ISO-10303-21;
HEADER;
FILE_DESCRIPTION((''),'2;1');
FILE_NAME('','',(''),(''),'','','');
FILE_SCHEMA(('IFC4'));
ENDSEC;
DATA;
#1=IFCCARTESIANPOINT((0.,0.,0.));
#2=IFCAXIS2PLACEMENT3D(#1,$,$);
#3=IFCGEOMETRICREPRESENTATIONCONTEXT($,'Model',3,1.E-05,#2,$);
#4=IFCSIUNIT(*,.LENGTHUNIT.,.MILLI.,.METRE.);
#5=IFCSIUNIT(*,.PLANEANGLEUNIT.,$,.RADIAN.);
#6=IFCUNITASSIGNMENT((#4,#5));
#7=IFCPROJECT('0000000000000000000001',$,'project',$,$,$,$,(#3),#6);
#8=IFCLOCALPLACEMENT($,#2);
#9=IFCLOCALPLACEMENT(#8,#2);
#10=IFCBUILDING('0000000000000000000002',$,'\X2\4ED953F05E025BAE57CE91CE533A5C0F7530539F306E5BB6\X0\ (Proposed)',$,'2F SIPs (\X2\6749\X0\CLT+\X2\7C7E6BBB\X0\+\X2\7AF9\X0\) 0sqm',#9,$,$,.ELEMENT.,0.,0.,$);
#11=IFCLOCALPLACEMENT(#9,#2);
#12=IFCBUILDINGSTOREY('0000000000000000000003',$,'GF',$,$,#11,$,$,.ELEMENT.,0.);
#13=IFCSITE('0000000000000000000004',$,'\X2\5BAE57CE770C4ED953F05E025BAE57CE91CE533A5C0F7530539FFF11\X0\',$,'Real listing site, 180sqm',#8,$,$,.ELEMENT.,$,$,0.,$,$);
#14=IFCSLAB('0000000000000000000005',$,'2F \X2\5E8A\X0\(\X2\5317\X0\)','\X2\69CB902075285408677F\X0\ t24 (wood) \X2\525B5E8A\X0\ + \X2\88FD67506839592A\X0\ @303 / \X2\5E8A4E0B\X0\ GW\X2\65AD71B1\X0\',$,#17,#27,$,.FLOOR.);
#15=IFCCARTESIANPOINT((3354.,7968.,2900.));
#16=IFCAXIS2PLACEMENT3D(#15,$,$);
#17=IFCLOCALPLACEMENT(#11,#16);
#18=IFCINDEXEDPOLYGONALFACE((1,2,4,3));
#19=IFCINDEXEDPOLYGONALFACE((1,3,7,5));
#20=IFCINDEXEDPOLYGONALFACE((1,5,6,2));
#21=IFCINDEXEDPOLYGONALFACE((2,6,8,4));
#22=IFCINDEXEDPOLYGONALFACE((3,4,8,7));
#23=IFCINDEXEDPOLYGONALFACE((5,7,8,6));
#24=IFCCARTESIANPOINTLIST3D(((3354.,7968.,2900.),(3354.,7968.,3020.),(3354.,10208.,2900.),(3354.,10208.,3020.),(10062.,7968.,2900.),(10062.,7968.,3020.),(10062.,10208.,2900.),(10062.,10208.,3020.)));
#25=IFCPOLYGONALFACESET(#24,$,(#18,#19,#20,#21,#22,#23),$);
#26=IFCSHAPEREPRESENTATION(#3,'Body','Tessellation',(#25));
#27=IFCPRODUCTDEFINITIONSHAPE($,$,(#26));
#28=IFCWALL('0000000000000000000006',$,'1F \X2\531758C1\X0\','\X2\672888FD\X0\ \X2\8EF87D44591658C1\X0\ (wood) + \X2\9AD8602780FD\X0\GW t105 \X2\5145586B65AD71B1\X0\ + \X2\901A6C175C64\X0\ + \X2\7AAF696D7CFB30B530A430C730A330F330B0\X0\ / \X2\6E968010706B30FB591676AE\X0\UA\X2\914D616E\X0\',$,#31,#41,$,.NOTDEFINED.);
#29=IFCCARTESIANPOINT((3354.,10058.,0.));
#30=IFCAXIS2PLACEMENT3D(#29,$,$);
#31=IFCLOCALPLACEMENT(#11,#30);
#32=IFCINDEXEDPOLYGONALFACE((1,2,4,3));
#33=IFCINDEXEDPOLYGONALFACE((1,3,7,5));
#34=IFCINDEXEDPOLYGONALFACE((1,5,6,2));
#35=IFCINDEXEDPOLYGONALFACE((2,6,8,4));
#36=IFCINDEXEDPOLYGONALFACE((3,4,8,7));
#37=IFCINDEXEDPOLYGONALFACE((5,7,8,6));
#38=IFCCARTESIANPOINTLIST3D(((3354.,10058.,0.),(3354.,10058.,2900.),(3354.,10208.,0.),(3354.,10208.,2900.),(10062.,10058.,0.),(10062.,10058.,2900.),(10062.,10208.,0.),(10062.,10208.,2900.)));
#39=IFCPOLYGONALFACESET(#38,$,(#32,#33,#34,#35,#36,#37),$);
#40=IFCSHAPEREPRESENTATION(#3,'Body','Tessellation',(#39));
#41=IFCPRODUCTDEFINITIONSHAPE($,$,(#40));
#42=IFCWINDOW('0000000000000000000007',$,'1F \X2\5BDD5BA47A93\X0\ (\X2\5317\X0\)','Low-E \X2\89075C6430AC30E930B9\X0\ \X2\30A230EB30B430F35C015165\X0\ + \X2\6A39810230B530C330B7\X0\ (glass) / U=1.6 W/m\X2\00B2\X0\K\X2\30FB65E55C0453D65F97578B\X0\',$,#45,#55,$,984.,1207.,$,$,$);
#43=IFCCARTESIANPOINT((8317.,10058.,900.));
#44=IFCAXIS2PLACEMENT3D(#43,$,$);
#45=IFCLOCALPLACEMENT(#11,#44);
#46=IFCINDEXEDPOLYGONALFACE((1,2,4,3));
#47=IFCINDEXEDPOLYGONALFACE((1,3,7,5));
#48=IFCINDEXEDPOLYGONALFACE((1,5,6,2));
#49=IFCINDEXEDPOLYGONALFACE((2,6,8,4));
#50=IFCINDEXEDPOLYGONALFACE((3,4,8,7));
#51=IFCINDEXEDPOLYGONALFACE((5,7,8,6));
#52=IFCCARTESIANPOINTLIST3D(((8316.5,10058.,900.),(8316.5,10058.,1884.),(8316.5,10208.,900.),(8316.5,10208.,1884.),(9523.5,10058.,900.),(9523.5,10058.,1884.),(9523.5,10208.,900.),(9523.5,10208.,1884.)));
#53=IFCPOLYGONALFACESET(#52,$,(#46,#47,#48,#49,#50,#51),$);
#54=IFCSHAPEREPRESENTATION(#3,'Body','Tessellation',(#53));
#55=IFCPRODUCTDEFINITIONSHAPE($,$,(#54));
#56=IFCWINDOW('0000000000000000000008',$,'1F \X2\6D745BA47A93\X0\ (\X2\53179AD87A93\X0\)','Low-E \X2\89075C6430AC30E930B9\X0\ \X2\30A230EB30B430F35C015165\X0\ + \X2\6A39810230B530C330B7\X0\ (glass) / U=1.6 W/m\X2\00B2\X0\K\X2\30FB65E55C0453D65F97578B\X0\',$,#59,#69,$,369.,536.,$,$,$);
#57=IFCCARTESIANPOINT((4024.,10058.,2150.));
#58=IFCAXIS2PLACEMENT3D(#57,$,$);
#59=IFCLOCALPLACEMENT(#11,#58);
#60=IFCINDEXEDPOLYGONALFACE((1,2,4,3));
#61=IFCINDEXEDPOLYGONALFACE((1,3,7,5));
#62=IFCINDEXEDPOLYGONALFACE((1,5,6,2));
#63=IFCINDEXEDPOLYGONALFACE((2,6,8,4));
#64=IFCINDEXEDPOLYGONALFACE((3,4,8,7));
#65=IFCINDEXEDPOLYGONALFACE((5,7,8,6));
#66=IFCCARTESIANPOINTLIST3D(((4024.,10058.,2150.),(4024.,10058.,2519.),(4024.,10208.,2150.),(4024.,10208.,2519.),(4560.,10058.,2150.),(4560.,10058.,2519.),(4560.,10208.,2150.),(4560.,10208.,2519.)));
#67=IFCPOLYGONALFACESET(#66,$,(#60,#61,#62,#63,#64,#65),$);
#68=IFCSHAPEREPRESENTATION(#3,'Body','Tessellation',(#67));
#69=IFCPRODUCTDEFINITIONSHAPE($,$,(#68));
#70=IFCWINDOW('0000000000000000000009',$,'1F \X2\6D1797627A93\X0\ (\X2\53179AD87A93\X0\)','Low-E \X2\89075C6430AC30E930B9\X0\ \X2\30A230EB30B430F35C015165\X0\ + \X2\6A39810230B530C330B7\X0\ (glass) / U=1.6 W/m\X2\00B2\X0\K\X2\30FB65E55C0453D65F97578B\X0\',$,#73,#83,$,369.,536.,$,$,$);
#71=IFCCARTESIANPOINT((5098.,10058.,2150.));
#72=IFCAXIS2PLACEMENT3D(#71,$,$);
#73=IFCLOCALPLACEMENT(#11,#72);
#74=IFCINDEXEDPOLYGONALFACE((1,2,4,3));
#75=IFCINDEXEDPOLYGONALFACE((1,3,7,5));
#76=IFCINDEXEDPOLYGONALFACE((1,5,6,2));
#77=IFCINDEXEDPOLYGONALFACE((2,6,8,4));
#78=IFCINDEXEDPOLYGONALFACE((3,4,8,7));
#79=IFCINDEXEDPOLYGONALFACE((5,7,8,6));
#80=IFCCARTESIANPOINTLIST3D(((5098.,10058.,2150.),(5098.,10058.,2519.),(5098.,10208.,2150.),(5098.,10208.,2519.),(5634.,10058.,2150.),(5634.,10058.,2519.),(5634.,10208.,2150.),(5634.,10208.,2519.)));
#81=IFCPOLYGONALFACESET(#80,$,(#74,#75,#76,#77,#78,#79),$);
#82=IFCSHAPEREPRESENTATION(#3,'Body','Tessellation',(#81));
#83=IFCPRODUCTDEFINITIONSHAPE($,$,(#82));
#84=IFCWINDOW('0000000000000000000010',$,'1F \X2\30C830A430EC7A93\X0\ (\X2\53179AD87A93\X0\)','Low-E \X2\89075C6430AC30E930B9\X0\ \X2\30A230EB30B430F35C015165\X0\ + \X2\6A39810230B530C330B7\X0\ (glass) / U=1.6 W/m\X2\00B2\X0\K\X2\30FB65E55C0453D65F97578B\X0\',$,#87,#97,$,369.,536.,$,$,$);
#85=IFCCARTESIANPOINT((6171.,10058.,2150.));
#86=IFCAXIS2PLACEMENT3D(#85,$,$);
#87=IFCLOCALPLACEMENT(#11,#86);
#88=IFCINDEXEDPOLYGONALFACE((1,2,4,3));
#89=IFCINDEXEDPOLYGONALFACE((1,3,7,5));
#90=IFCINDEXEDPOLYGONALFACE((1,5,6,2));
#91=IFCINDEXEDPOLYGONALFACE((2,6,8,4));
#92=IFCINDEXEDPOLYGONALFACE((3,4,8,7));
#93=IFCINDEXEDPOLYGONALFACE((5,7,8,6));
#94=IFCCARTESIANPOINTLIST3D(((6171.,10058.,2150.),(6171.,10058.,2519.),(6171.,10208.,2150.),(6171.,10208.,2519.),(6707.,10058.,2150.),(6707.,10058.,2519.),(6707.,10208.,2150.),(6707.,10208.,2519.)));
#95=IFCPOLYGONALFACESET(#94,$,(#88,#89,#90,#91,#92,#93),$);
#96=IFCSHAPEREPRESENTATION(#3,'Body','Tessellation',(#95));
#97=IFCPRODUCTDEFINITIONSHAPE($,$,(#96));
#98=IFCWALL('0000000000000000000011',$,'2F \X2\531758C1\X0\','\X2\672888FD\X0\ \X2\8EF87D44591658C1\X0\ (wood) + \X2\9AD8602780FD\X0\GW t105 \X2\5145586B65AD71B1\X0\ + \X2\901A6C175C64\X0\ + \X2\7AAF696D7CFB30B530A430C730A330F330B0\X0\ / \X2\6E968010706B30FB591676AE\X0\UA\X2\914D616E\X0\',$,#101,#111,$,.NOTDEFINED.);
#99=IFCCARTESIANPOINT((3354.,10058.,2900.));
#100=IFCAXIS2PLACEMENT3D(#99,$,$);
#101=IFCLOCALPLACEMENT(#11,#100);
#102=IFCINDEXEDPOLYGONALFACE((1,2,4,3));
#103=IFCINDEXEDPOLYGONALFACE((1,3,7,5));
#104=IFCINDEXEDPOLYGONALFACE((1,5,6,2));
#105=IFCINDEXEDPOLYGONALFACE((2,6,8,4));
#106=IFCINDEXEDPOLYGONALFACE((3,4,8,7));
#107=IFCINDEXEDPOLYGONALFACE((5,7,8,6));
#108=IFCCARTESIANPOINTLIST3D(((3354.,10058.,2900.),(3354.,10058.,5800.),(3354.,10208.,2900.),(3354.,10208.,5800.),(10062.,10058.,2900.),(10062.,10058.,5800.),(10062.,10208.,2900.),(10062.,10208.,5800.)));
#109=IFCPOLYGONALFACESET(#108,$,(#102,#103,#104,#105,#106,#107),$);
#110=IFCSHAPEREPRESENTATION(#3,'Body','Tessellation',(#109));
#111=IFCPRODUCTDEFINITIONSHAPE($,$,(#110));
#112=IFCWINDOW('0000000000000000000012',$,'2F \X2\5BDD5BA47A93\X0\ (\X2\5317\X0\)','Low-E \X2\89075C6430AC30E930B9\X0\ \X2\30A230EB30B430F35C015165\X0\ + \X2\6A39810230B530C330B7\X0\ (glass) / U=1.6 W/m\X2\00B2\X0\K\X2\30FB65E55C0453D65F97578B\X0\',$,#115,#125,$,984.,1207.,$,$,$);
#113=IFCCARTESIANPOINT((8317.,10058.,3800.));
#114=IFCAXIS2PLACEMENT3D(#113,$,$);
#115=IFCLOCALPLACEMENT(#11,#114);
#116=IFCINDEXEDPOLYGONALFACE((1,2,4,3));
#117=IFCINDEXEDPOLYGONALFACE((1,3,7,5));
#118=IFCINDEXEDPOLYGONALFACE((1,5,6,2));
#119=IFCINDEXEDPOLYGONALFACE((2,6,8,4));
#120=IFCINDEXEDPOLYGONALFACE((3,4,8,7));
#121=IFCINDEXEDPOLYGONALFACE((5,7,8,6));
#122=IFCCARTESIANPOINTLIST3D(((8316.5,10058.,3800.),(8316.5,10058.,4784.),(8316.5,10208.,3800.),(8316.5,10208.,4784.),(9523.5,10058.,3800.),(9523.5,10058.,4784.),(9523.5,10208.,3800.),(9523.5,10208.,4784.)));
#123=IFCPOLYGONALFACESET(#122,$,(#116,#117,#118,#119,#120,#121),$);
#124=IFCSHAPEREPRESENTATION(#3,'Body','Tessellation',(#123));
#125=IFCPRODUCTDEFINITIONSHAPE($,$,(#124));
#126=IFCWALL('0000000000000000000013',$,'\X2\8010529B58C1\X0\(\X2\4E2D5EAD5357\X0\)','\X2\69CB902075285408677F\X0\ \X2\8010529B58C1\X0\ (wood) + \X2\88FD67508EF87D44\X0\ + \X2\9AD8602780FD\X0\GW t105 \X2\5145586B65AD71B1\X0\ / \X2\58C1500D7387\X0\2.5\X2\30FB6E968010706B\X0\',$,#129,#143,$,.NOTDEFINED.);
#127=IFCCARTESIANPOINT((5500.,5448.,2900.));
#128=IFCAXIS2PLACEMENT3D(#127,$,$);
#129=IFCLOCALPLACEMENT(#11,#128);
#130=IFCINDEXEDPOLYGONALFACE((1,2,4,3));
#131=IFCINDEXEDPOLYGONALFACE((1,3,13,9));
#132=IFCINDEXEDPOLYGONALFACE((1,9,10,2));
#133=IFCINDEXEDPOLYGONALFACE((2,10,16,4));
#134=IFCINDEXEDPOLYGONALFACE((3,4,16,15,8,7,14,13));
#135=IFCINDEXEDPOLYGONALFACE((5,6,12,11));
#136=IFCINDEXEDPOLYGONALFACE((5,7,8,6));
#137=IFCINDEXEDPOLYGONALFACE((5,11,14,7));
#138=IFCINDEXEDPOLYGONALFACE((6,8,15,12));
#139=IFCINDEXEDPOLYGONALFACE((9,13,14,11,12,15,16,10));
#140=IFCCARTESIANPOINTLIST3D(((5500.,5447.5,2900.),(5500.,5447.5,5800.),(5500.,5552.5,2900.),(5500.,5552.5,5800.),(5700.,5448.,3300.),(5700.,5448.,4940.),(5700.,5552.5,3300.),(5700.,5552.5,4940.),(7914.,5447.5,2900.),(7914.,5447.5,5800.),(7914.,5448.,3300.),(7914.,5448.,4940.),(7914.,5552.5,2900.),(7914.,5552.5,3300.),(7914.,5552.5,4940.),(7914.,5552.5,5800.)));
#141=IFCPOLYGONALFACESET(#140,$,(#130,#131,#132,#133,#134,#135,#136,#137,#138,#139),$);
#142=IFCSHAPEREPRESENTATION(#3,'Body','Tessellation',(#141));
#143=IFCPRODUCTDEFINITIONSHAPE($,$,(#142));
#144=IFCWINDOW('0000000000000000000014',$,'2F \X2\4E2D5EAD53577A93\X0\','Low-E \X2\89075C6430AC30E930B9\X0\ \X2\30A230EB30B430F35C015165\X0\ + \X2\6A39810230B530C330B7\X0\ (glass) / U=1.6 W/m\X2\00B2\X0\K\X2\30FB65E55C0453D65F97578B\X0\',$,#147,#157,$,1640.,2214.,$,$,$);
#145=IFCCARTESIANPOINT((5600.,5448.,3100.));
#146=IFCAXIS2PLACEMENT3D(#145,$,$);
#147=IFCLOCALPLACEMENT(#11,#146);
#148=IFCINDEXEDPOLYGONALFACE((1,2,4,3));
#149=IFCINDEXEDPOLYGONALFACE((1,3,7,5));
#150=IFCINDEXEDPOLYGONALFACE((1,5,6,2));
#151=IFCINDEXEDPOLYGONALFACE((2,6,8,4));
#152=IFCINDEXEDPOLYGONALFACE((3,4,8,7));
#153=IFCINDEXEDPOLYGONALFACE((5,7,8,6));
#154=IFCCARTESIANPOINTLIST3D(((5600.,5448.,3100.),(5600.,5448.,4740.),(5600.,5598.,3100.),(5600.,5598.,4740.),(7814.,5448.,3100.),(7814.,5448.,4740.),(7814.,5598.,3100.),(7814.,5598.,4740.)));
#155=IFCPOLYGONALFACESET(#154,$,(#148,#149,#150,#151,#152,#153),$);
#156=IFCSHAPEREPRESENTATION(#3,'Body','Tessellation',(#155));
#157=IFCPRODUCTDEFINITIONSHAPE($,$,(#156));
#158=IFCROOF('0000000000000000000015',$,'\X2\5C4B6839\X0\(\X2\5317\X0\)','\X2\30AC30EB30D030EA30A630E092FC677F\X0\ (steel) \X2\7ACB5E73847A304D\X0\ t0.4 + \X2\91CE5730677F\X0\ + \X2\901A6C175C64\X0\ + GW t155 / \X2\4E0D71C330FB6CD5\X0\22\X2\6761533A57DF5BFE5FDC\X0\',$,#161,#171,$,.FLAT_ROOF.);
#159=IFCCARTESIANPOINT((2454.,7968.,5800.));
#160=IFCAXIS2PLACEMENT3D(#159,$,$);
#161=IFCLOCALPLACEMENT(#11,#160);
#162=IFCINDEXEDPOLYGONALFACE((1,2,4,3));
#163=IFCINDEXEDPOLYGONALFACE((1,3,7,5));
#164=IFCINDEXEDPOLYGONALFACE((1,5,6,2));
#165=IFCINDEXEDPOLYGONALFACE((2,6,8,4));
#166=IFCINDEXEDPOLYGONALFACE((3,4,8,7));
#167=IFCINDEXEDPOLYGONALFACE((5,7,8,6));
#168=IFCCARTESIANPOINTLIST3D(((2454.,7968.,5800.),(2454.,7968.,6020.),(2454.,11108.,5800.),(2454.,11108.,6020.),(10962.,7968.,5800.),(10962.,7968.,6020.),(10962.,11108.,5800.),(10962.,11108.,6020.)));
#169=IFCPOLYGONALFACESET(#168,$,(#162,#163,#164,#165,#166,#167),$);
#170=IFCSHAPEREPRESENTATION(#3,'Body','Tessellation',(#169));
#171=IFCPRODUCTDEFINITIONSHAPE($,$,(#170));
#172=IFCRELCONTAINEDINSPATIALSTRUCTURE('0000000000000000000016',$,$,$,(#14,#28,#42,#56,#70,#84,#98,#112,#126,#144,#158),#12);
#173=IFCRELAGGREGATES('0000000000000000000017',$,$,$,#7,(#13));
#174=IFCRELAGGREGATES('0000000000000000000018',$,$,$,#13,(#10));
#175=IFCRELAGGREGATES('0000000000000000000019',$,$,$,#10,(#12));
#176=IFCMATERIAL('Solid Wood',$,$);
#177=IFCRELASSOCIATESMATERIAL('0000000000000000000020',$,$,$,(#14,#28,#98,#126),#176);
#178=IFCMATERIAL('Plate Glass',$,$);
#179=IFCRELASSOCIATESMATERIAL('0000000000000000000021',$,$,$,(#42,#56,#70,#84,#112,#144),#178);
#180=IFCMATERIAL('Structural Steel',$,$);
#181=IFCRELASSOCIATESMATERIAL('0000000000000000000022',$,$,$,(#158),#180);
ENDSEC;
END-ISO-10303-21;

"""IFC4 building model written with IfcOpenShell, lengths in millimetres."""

from ifc_helpers import new_model, si_unit, frame, frame_2d, origin, place, context, project, spatial, rectangle, extrude, material, element, fill, save


model = new_model("IFC4")

# Units and contexts
model_context = context("Model", 3, precision=1e-05, world=origin())
ifc_project = project(units=[si_unit("LENGTHUNIT", "METRE", prefix="MILLI"), si_unit("PLANEANGLEUNIT", "RADIAN")], contexts=[model_context])

# Site, building, storey
site_placement = place(None, origin())
site = spatial("IfcSite", under=ifc_project, at=site_placement, Name="宮城県仙台市宮城野区小田原１", ObjectType="Real listing site, 180sqm", CompositionType="ELEMENT", RefElevation=0.0)
building_placement = place(site_placement, origin())
building = spatial("IfcBuilding", under=site, at=building_placement, Name="仙台市宮城野区小田原の家 (Proposed)", ObjectType="2F SIPs (杉CLT+籾殻+竹) 0sqm", CompositionType="ELEMENT", ElevationOfRefHeight=0.0, ElevationOfTerrain=0.0)
storey_placement = place(building_placement, origin())
storey = spatial("IfcBuildingStorey", under=building, at=storey_placement, Name="GF", CompositionType="ELEMENT", Elevation=0.0)

# Slab
ifc_material_1 = material(Name="Solid Wood")
slab_1_placement = place(storey_placement, frame((3354.0, 7968.0, 2900.0)))
element("IfcSlab", 1, at=slab_1_placement, inside=storey, material=ifc_material_1, Name="2F 床(北)", Description="構造用合板 t24 (wood) 剛床 + 製材根太 @303 / 床下 GW断熱", PredefinedType="FLOOR", context=model_context, shape_type="SweptSolid", body=[
    extrude(rectangle(XDim=6708.0, YDim=2240.0, at=frame_2d((3354.0, 1120.0))), frame((3354.0, 7968.0, 2900.0)), (0.0, 0.0, 1.0), 120.0),
])

# Wall, openings, windows
wall_1_placement = place(storey_placement, frame((3354.0, 10058.0, 0.0)))
wall_1 = element("IfcWall", 2, at=wall_1_placement, inside=storey, material=ifc_material_1, Name="1F 北壁", Description="木製 軸組外壁 (wood) + 高性能GW t105 充填断熱 + 通気層 + 窯業系サイディング / 準耐火・外皮UA配慮", PredefinedType="NOTDEFINED", context=model_context, shape_type="SweptSolid", body=[
    extrude(rectangle(XDim=6708.0, YDim=150.0, at=frame_2d((3354.0, 75.0))), frame((3354.0, 10058.0, 0.0)), (0.0, 0.0, 1.0), 2900.0),
])
opening_1_placement = place(storey_placement, frame((8317.0, 10058.0, 900.0)))
opening_1 = element("IfcOpeningElement", 3, at=opening_1_placement, cuts=wall_1, PredefinedType="NOTDEFINED", context=model_context, shape_type="SweptSolid", body=[
    extrude(rectangle(XDim=1207.0, YDim=150.0, at=frame_2d((603.0, 75.0))), frame((8317.0, 10058.0, 900.0)), (0.0, 0.0, 1.0), 984.0),
])
opening_2_placement = place(storey_placement, frame((4024.0, 10058.0, 2150.0)))
opening_2 = element("IfcOpeningElement", 4, at=opening_2_placement, cuts=wall_1, PredefinedType="NOTDEFINED", context=model_context, shape_type="SweptSolid", body=[
    extrude(rectangle(XDim=536.0, YDim=150.0, at=frame_2d((268.0, 75.0))), frame((4024.0, 10058.0, 2150.0)), (0.0, 0.0, 1.0), 369.0),
])
opening_3_placement = place(storey_placement, frame((5098.0, 10058.0, 2150.0)))
opening_3 = element("IfcOpeningElement", 5, at=opening_3_placement, cuts=wall_1, PredefinedType="NOTDEFINED", context=model_context, shape_type="SweptSolid", body=[
    extrude(rectangle(XDim=536.0, YDim=150.0, at=frame_2d((268.0, 75.0))), frame((5098.0, 10058.0, 2150.0)), (0.0, 0.0, 1.0), 369.0),
])
opening_4_placement = place(storey_placement, frame((6171.0, 10058.0, 2150.0)))
opening_4 = element("IfcOpeningElement", 6, at=opening_4_placement, cuts=wall_1, PredefinedType="NOTDEFINED", context=model_context, shape_type="SweptSolid", body=[
    extrude(rectangle(XDim=536.0, YDim=150.0, at=frame_2d((268.0, 75.0))), frame((6171.0, 10058.0, 2150.0)), (0.0, 0.0, 1.0), 369.0),
])
ifc_material_2 = material(Name="Plate Glass")
window_1_placement = place(storey_placement, frame((8317.0, 10058.0, 900.0)))
window_1 = element("IfcWindow", 7, at=window_1_placement, inside=storey, material=ifc_material_2, Name="1F 寝室窓 (北)", Description="Low-E 複層ガラス アルゴン封入 + 樹脂サッシ (glass) / U=1.6 W/m²K・日射取得型", OverallHeight=984.0, OverallWidth=1207.0, context=model_context, shape_type="SweptSolid", body=[
    extrude(rectangle(XDim=1207.0, YDim=150.0, at=frame_2d((603.0, 75.0))), frame((8317.0, 10058.0, 900.0)), (0.0, 0.0, 1.0), 984.0),
])
fill(opening_1, window_1)
window_2_placement = place(storey_placement, frame((4024.0, 10058.0, 2150.0)))
window_2 = element("IfcWindow", 8, at=window_2_placement, inside=storey, material=ifc_material_2, Name="1F 浴室窓 (北高窓)", Description="Low-E 複層ガラス アルゴン封入 + 樹脂サッシ (glass) / U=1.6 W/m²K・日射取得型", OverallHeight=369.0, OverallWidth=536.0, context=model_context, shape_type="SweptSolid", body=[
    extrude(rectangle(XDim=536.0, YDim=150.0, at=frame_2d((268.0, 75.0))), frame((4024.0, 10058.0, 2150.0)), (0.0, 0.0, 1.0), 369.0),
])
fill(opening_2, window_2)
window_3_placement = place(storey_placement, frame((5098.0, 10058.0, 2150.0)))
window_3 = element("IfcWindow", 9, at=window_3_placement, inside=storey, material=ifc_material_2, Name="1F 洗面窓 (北高窓)", Description="Low-E 複層ガラス アルゴン封入 + 樹脂サッシ (glass) / U=1.6 W/m²K・日射取得型", OverallHeight=369.0, OverallWidth=536.0, context=model_context, shape_type="SweptSolid", body=[
    extrude(rectangle(XDim=536.0, YDim=150.0, at=frame_2d((268.0, 75.0))), frame((5098.0, 10058.0, 2150.0)), (0.0, 0.0, 1.0), 369.0),
])
fill(opening_3, window_3)
window_4_placement = place(storey_placement, frame((6171.0, 10058.0, 2150.0)))
window_4 = element("IfcWindow", 10, at=window_4_placement, inside=storey, material=ifc_material_2, Name="1F トイレ窓 (北高窓)", Description="Low-E 複層ガラス アルゴン封入 + 樹脂サッシ (glass) / U=1.6 W/m²K・日射取得型", OverallHeight=369.0, OverallWidth=536.0, context=model_context, shape_type="SweptSolid", body=[
    extrude(rectangle(XDim=536.0, YDim=150.0, at=frame_2d((268.0, 75.0))), frame((6171.0, 10058.0, 2150.0)), (0.0, 0.0, 1.0), 369.0),
])
fill(opening_4, window_4)

# Walls, openings, windows
wall_2_placement = place(storey_placement, frame((3354.0, 10058.0, 2900.0)))
wall_2 = element("IfcWall", 11, at=wall_2_placement, inside=storey, material=ifc_material_1, Name="2F 北壁", Description="木製 軸組外壁 (wood) + 高性能GW t105 充填断熱 + 通気層 + 窯業系サイディング / 準耐火・外皮UA配慮", PredefinedType="NOTDEFINED", context=model_context, shape_type="SweptSolid", body=[
    extrude(rectangle(XDim=6708.0, YDim=150.0, at=frame_2d((3354.0, 75.0))), frame((3354.0, 10058.0, 2900.0)), (0.0, 0.0, 1.0), 2900.0),
])
opening_5_placement = place(storey_placement, frame((8317.0, 10058.0, 3800.0)))
opening_5 = element("IfcOpeningElement", 12, at=opening_5_placement, cuts=wall_2, PredefinedType="NOTDEFINED", context=model_context, shape_type="SweptSolid", body=[
    extrude(rectangle(XDim=1207.0, YDim=150.0, at=frame_2d((603.0, 75.0))), frame((8317.0, 10058.0, 3800.0)), (0.0, 0.0, 1.0), 984.0),
])
window_5_placement = place(storey_placement, frame((8317.0, 10058.0, 3800.0)))
window_5 = element("IfcWindow", 13, at=window_5_placement, inside=storey, material=ifc_material_2, Name="2F 寝室窓 (北)", Description="Low-E 複層ガラス アルゴン封入 + 樹脂サッシ (glass) / U=1.6 W/m²K・日射取得型", OverallHeight=984.0, OverallWidth=1207.0, context=model_context, shape_type="SweptSolid", body=[
    extrude(rectangle(XDim=1207.0, YDim=150.0, at=frame_2d((603.0, 75.0))), frame((8317.0, 10058.0, 3800.0)), (0.0, 0.0, 1.0), 984.0),
])
fill(opening_5, window_5)
wall_3_placement = place(storey_placement, frame((5500.0, 5448.0, 2900.0)))
wall_3 = element("IfcWall", 14, at=wall_3_placement, inside=storey, material=ifc_material_1, Name="耐力壁(中庭南)", Description="構造用合板 耐力壁 (wood) + 製材軸組 + 高性能GW t105 充填断熱 / 壁倍率2.5・準耐火", PredefinedType="NOTDEFINED", context=model_context, shape_type="SweptSolid", body=[
    extrude(rectangle(XDim=2414.0, YDim=105.0, at=frame_2d((1207.0, 52.0))), frame((5500.0, 5448.0, 2900.0)), (0.0, 0.0, 1.0), 2900.0),
])
opening_6_placement = place(storey_placement, frame((5600.0, 5448.0, 3100.0)))
opening_6 = element("IfcOpeningElement", 15, at=opening_6_placement, cuts=wall_3, PredefinedType="NOTDEFINED", context=model_context, shape_type="SweptSolid", body=[
    extrude(rectangle(XDim=2214.0, YDim=150.0, at=frame_2d((1107.0, 75.0))), frame((5600.0, 5448.0, 3100.0)), (0.0, 0.0, 1.0), 1640.0),
])
window_6_placement = place(storey_placement, frame((5600.0, 5448.0, 3100.0)))
window_6 = element("IfcWindow", 16, at=window_6_placement, inside=storey, material=ifc_material_2, Name="2F 中庭南窓", Description="Low-E 複層ガラス アルゴン封入 + 樹脂サッシ (glass) / U=1.6 W/m²K・日射取得型", OverallHeight=1640.0, OverallWidth=2214.0, context=model_context, shape_type="SweptSolid", body=[
    extrude(rectangle(XDim=2214.0, YDim=150.0, at=frame_2d((1107.0, 75.0))), frame((5600.0, 5448.0, 3100.0)), (0.0, 0.0, 1.0), 1640.0),
])
fill(opening_6, window_6)

# Roof
ifc_material_3 = material(Name="Structural Steel")
for number, where, name in (
    (17, (2454.0, 7968.0, 5800.0), "屋根(北)"),
):
    element("IfcRoof", number, at=place(storey_placement, frame(where)), inside=storey, material=ifc_material_3, Name=name, Description="ガルバリウム鋼板 (steel) 立平葺き t0.4 + 野地板 + 通気層 + GW t155 / 不燃・法22条区域対応", PredefinedType="FLAT_ROOF", context=model_context, shape_type="SweptSolid", body=[
        extrude(rectangle(XDim=8508.0, YDim=3140.0, at=frame_2d((4254.0, 1570.0))), frame((2454.0, 7968.0, 5800.0)), (0.0, 0.0, 1.0), 220.0),
    ])

save(model, "model.ifc")
